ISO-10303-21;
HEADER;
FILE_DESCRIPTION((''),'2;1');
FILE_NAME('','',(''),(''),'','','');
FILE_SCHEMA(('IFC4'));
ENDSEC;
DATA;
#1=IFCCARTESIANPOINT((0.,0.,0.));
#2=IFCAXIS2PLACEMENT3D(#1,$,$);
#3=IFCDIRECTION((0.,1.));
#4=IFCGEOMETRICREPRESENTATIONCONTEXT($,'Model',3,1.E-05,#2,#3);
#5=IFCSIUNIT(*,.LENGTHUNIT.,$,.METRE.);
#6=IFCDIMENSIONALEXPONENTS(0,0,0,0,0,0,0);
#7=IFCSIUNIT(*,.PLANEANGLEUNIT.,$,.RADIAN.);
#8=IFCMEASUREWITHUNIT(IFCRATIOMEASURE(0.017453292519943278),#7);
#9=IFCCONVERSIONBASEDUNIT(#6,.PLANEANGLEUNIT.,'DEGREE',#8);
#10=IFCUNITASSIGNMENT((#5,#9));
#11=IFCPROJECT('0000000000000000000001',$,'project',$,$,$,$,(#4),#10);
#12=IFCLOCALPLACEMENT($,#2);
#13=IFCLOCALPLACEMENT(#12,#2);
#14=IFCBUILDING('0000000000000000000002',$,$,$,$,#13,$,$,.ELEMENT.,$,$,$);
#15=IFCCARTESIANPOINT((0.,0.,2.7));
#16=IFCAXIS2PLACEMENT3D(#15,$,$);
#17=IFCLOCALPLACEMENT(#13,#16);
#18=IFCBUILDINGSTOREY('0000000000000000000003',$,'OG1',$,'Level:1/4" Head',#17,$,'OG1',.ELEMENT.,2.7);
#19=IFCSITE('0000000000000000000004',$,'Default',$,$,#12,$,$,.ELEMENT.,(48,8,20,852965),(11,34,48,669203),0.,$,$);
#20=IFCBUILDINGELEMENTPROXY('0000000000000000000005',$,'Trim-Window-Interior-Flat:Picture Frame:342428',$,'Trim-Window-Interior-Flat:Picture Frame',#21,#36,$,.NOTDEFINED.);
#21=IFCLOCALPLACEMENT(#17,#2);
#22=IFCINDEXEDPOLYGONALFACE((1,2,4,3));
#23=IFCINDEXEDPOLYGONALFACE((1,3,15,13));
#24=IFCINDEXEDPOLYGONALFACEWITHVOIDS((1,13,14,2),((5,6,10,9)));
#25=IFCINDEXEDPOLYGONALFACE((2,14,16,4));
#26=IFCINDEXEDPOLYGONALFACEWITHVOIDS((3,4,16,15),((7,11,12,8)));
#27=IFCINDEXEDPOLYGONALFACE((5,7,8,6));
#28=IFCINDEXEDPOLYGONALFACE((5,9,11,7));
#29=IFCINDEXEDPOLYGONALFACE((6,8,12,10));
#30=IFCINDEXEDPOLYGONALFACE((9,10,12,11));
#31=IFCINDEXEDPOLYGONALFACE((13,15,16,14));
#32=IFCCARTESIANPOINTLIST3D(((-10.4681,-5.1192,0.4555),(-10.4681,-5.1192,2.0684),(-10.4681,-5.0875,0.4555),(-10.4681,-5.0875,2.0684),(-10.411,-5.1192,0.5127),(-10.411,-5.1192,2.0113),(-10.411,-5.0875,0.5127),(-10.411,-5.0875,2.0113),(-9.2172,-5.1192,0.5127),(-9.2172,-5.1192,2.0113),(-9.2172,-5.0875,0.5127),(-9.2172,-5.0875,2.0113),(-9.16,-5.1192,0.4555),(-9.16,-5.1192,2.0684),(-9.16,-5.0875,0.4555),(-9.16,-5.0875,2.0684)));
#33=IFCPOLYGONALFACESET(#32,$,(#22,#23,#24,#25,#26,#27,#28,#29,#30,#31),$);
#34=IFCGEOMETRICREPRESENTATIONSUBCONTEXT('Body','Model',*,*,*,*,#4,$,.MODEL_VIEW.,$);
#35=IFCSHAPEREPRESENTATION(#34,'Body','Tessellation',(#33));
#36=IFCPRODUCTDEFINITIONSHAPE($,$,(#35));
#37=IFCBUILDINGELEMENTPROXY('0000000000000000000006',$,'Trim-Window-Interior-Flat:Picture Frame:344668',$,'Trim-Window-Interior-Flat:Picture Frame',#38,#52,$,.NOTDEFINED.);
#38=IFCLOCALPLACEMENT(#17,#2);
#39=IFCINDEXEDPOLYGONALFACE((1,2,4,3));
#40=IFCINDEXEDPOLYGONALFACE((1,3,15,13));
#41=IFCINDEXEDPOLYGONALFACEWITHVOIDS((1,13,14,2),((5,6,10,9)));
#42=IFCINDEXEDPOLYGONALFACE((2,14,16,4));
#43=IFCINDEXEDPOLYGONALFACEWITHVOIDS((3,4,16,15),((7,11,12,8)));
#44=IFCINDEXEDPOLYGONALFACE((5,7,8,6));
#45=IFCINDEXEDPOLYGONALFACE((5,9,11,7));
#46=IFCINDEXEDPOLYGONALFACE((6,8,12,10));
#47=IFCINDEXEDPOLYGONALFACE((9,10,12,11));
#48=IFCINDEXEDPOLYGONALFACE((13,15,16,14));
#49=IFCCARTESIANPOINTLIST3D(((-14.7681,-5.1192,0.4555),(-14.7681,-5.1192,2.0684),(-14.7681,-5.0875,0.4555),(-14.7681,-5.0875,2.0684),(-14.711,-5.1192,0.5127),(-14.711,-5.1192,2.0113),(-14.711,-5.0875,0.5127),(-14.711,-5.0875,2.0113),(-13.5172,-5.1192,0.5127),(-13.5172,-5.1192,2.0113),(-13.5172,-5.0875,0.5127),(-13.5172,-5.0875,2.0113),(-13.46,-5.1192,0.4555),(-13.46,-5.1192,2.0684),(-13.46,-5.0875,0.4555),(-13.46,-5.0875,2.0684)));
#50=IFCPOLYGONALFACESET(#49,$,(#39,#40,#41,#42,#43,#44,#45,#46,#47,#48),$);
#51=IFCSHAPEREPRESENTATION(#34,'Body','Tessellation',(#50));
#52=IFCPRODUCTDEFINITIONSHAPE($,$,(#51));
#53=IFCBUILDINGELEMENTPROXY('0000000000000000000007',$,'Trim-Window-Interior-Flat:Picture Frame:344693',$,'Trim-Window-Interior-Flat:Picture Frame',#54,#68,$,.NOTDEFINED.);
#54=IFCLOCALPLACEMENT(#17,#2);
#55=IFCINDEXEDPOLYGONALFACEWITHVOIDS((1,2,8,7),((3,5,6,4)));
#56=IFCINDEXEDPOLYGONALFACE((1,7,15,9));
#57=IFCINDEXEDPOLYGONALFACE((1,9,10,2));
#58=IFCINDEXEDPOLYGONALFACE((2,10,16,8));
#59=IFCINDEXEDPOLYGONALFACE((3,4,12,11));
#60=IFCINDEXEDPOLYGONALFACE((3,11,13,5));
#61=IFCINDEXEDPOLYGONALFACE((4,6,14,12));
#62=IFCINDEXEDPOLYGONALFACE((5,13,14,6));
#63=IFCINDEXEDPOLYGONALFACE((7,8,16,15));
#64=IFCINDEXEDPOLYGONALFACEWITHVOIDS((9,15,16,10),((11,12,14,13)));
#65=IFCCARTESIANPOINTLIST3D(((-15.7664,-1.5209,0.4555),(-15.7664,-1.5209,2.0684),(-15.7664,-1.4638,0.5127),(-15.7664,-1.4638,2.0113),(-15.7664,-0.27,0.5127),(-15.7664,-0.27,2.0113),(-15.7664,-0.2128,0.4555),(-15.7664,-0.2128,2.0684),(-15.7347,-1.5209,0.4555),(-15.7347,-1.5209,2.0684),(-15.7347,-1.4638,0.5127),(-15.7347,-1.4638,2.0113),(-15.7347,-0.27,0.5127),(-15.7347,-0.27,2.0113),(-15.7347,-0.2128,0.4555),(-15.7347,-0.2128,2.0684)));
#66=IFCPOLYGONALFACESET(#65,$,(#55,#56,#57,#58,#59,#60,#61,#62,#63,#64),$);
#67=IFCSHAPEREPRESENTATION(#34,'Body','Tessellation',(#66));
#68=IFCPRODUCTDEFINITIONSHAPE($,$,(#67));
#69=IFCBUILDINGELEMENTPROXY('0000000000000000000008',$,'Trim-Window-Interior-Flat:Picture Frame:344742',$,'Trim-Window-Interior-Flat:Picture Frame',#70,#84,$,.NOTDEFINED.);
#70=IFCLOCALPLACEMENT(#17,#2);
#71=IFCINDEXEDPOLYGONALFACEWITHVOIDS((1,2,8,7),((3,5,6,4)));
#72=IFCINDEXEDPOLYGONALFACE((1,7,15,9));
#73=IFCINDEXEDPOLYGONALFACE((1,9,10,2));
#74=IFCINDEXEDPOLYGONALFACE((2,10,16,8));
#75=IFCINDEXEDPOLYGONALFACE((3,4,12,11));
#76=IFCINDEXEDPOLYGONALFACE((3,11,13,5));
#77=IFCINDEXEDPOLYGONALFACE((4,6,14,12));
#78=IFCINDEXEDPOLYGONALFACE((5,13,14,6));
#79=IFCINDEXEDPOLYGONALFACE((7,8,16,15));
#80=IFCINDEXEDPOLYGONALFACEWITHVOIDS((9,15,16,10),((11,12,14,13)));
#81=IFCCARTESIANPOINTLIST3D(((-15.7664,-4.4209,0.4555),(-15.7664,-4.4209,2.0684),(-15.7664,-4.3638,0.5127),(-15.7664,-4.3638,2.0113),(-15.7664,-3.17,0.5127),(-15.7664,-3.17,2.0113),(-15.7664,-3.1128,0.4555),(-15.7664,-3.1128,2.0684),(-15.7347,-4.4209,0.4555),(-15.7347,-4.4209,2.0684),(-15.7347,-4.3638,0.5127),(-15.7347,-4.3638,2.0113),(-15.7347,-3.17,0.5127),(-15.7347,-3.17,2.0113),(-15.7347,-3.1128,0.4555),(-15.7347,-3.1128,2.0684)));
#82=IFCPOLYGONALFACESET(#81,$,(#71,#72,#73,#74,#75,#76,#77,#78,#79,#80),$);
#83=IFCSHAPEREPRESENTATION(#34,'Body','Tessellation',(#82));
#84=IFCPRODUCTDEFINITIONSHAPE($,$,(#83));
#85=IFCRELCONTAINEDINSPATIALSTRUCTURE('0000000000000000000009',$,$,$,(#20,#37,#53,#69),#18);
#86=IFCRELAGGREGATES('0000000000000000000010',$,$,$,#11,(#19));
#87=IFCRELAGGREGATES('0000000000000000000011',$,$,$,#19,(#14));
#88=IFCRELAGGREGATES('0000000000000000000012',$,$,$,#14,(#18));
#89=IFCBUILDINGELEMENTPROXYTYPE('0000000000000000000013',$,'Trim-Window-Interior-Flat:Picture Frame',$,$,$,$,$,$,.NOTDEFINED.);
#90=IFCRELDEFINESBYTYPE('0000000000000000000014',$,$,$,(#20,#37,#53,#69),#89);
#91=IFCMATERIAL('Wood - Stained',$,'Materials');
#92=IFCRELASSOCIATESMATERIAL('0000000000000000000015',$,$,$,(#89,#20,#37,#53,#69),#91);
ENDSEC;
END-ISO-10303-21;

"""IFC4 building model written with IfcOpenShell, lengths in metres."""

from ifc_helpers import new_model, entity, si_unit, converted_unit, direction, frame, origin, place, context, subcontext, project, spatial, indexed_curve, outline, extrude, source, transform, mapped, material, type_object, type_shapes, element, save


model = new_model("IFC4")

# Units and contexts
model_context = context("Model", 3, precision=1e-05, world=origin(), true_north=direction((0.0, 1.0)))
body_context = subcontext(model_context, "Body", "Model", "MODEL_VIEW")
ifc_project = project(units=[si_unit("LENGTHUNIT", "METRE"), converted_unit("PLANEANGLEUNIT", "DEGREE", entity("IfcRatioMeasure", 0.017453292519943278), si_unit("PLANEANGLEUNIT", "RADIAN"), dimensions=[0, 0, 0, 0, 0, 0, 0])], contexts=[model_context])

# Site, building, storey
site_placement = place(None, origin())
site = spatial("IfcSite", under=ifc_project, at=site_placement, Name="Default", CompositionType="ELEMENT", RefLatitude=(48, 8, 20, 852965), RefLongitude=(11, 34, 48, 669203), RefElevation=0.0)
building_placement = place(site_placement, origin())
building = spatial("IfcBuilding", under=site, at=building_placement, CompositionType="ELEMENT")
storey_placement = place(building_placement, frame((0.0, 0.0, 2.7)))
storey = spatial("IfcBuildingStorey", under=building, at=storey_placement, Name="OG1", ObjectType="Level:1/4\" Head", LongName="OG1", CompositionType="ELEMENT", Elevation=2.7)

# Building element proxies
ifc_material_1 = material(Name="Wood - Stained", Category="Materials")
building_element_proxy_type_1 = type_object("IfcBuildingElementProxyType", Name="Trim-Window-Interior-Flat:Picture Frame", PredefinedType="NOTDEFINED", material=ifc_material_1)
shared_shape_1 = source(origin(), body_context, "Body", "SweptSolid", [
    extrude(outline(indexed_curve([(-0.654, -0.8064), (0.654, -0.8064), (0.654, 0.8064), (-0.654, 0.8064), (-0.654, -0.8064)], self_intersect=False), holes=[indexed_curve([(-0.5969, -0.7493), (-0.5969, 0.7493), (0.5969, 0.7493), (0.5969, -0.7493), (-0.5969, -0.7493)], self_intersect=False)]), frame((0.0, -0.762, 0.0), z_axis=(0.0, 0.0, 1.0), x_axis=(-1.0, 0.0, 0.0)), (0.0, 0.0, 1.0), 0.0317),
])
type_shapes(building_element_proxy_type_1, [shared_shape_1])
for number, where, z_axis, x_axis, name in (
    (1, (-9.8141, -5.1192, 2.024), (0.0, 1.0, 0.0), (-1.0, 0.0, 0.0), "Trim-Window-Interior-Flat:Picture Frame:342428"),
    (2, (-14.1141, -5.1192, 2.024), (0.0, 1.0, 0.0), (-1.0, 0.0, 0.0), "Trim-Window-Interior-Flat:Picture Frame:344668"),
    (3, (-15.7664, -0.8669, 2.024), (1.0, 0.0, 0.0), (0.0, 1.0, 0.0), "Trim-Window-Interior-Flat:Picture Frame:344693"),
    (4, (-15.7664, -3.7669, 2.024), (1.0, 0.0, 0.0), (0.0, 1.0, 0.0), "Trim-Window-Interior-Flat:Picture Frame:344742"),
):
    element("IfcBuildingElementProxy", number, at=place(storey_placement, frame(where, z_axis=z_axis, x_axis=x_axis)), inside=storey, type_object=building_element_proxy_type_1, material=ifc_material_1, Name=name, ObjectType="Trim-Window-Interior-Flat:Picture Frame", PredefinedType="NOTDEFINED", context=body_context, shape_type="MappedRepresentation", body=[
        mapped(shared_shape_1, transform((0.0, 0.0, 0.0), scale=1.0)),
    ])

save(model, "model.ifc")
